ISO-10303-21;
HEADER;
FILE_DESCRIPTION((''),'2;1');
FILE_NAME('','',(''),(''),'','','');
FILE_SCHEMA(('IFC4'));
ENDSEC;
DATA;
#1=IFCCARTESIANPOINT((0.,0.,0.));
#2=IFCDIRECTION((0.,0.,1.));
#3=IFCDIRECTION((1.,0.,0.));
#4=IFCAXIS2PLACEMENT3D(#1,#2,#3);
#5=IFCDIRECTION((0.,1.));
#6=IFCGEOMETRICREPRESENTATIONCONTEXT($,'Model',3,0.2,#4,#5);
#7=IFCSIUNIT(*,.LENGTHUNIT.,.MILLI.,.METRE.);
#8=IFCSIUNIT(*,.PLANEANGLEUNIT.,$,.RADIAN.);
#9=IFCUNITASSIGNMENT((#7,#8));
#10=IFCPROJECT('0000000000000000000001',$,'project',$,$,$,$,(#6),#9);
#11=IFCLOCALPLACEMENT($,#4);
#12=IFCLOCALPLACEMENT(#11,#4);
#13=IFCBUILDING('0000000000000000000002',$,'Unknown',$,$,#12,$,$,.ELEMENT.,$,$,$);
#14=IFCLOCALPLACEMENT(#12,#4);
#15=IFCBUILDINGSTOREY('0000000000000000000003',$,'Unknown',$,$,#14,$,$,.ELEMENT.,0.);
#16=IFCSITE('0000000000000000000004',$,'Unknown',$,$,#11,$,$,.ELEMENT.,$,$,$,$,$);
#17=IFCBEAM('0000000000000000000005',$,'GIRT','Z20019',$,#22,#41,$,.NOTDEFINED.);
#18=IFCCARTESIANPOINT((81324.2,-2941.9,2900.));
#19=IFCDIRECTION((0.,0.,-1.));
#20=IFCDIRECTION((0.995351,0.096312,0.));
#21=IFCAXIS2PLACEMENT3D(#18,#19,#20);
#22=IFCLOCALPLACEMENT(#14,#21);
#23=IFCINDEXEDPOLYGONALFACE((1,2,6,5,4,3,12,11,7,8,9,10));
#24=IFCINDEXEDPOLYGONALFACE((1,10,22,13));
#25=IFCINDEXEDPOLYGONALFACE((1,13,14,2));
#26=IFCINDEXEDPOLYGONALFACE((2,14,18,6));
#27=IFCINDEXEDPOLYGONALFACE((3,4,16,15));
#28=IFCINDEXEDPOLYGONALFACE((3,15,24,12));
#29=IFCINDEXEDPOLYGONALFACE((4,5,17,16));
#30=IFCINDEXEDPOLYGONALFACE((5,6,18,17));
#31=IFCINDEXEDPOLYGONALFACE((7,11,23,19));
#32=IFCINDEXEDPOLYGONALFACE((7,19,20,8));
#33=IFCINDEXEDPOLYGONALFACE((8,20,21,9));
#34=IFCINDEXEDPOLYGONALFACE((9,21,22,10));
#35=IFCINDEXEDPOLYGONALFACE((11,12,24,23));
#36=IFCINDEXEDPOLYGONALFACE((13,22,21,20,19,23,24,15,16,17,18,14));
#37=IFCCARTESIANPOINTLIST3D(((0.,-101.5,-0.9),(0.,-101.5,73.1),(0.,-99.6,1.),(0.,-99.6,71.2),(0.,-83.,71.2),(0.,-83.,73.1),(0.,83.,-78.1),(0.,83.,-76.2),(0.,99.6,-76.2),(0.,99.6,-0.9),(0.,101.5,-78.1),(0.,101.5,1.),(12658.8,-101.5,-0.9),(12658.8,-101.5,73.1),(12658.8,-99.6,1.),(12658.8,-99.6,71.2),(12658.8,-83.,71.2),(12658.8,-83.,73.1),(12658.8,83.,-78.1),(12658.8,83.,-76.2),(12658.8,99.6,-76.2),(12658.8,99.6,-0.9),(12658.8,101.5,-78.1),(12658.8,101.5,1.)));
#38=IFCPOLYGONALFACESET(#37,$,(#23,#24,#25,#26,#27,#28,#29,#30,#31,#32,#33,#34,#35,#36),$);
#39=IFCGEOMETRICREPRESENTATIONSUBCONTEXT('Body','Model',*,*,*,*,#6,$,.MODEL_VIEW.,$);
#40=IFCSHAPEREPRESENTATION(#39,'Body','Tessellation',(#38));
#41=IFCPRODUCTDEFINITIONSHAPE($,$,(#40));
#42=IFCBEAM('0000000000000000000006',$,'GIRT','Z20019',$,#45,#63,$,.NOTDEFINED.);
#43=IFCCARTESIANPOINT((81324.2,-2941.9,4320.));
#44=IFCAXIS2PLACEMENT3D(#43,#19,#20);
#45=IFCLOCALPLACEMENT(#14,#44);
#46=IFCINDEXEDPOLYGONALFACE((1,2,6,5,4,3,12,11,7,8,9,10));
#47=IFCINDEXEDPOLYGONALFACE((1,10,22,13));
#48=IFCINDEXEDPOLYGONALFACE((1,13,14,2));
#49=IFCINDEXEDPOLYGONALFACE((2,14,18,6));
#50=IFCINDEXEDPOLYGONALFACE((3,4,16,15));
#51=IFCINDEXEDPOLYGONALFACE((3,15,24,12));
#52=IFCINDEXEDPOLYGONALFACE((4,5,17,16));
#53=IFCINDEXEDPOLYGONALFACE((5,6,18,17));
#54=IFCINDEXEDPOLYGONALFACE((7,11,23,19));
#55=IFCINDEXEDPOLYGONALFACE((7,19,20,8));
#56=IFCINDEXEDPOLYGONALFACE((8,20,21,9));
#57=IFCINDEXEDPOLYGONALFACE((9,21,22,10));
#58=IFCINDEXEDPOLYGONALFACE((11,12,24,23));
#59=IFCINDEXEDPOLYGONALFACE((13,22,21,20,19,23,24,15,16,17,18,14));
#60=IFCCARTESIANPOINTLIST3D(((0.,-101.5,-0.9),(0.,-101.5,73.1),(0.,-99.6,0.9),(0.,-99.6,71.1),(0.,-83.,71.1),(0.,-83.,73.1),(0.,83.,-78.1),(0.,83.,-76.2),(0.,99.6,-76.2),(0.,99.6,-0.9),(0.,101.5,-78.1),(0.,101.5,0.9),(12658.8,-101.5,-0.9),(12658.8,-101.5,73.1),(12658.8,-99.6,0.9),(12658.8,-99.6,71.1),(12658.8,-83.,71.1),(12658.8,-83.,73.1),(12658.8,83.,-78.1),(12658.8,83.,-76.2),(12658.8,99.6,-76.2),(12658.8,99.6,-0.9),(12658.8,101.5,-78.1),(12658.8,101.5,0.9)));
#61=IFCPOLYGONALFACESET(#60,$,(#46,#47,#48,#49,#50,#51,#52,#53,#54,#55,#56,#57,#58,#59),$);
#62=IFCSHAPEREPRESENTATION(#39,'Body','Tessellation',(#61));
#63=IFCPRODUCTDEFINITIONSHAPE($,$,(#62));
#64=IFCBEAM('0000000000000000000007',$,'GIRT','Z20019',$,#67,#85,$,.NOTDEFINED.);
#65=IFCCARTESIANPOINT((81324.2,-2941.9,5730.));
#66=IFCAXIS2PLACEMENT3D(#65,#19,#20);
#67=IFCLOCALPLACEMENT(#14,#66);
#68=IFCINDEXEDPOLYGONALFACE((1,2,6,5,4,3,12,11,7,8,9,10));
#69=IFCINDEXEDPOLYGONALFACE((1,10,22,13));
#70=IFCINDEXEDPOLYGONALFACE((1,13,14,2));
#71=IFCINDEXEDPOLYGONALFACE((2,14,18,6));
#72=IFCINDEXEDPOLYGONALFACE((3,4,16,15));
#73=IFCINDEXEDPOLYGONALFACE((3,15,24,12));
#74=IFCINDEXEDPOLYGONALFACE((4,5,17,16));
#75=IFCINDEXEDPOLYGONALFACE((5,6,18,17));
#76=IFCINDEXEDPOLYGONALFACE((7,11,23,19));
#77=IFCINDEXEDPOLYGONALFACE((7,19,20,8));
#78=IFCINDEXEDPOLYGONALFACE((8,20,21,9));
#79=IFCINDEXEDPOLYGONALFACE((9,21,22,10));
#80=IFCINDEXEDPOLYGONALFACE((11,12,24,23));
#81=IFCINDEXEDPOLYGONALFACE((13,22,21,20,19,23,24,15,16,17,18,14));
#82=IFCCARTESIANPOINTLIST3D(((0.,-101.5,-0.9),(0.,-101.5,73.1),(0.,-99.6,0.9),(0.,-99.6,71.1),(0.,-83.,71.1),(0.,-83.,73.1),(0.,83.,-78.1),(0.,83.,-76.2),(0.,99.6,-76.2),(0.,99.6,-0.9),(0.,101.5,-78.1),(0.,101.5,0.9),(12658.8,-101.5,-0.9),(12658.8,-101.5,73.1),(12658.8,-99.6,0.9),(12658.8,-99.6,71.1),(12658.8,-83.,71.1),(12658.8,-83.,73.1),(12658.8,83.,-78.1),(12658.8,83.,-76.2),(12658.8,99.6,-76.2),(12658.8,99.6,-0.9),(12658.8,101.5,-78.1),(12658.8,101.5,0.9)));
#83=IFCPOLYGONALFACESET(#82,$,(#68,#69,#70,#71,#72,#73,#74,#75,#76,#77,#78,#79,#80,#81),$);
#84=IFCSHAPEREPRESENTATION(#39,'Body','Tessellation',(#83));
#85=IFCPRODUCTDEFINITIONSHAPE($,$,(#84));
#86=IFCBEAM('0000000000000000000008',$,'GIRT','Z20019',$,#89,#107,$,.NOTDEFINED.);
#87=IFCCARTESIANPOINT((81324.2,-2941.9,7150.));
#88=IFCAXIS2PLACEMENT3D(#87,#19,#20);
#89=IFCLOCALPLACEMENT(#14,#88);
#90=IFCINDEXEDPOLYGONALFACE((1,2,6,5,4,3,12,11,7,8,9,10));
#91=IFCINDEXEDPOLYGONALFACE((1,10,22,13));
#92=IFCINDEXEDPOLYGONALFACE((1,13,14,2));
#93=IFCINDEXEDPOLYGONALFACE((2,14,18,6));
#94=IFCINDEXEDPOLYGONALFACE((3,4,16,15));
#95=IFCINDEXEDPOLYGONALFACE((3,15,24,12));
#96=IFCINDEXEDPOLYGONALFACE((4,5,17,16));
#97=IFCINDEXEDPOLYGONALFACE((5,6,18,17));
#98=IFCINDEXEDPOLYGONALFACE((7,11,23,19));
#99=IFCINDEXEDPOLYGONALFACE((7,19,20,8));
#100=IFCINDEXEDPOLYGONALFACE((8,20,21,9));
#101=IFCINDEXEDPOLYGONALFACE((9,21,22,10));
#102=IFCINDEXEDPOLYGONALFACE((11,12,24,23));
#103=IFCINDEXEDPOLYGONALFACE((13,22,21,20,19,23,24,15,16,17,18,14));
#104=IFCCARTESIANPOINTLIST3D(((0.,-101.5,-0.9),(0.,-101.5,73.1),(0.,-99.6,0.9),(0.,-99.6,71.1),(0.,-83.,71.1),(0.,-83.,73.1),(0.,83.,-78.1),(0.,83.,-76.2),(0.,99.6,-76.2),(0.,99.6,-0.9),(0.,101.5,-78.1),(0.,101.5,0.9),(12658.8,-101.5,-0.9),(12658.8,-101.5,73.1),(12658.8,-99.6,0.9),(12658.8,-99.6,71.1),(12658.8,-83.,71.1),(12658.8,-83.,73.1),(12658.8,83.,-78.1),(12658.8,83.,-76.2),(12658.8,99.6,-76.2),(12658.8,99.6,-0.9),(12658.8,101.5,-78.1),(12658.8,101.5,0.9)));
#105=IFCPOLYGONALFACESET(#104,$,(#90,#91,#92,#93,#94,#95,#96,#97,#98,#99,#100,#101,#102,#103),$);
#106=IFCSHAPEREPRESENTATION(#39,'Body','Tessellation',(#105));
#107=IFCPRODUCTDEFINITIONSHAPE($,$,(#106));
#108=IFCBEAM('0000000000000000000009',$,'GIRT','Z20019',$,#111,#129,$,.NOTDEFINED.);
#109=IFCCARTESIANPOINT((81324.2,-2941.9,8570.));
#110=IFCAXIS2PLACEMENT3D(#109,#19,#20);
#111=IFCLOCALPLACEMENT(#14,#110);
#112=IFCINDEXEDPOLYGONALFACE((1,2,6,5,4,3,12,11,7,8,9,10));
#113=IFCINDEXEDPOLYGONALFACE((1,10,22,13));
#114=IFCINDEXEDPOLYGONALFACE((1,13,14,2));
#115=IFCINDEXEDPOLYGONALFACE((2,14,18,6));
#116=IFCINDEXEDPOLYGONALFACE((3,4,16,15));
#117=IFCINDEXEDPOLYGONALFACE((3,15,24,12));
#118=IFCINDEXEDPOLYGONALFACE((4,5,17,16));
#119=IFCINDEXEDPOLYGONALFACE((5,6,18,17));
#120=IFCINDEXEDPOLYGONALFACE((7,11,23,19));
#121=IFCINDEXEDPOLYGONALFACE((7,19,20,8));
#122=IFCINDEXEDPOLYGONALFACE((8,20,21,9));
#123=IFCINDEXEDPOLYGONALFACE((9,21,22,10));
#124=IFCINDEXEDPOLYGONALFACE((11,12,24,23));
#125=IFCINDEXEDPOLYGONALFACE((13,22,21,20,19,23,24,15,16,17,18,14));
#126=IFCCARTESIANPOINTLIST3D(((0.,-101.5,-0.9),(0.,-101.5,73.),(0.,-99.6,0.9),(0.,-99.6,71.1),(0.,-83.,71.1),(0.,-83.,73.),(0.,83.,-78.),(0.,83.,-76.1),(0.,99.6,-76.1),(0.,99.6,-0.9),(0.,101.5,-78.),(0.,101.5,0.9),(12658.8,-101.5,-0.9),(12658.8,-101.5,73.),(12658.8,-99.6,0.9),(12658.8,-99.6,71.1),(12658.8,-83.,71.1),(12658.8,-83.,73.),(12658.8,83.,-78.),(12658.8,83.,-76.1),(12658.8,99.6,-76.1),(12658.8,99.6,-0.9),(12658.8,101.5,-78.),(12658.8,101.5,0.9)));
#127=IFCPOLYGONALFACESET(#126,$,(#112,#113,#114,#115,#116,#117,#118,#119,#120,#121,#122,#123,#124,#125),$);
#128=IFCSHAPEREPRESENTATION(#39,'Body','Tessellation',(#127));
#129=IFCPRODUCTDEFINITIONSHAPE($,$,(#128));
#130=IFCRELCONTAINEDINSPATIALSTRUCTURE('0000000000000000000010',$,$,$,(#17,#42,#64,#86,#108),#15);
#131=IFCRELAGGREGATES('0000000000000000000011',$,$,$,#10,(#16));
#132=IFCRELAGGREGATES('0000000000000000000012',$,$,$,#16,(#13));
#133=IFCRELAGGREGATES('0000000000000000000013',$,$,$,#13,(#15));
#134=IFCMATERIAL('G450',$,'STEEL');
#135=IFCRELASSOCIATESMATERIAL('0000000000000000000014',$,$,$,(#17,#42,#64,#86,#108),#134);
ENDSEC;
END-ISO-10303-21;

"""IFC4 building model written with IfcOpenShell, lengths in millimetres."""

from ifc_helpers import new_model, si_unit, direction, frame, origin_with_axes, place, context, subcontext, project, spatial, line, indexed_curve, outline, extrude, material, element, save


model = new_model("IFC4")

# Units and contexts
model_context = context("Model", 3, precision=0.2, world=origin_with_axes(), true_north=direction((0.0, 1.0)))
body_context = subcontext(model_context, "Body", "Model", "MODEL_VIEW")
ifc_project = project(units=[si_unit("LENGTHUNIT", "METRE", prefix="MILLI"), si_unit("PLANEANGLEUNIT", "RADIAN")], contexts=[model_context])

# Site, building, storey
site_placement = place(None, origin_with_axes())
site = spatial("IfcSite", under=ifc_project, at=site_placement, Name="Unknown", CompositionType="ELEMENT")
building_placement = place(site_placement, origin_with_axes())
building = spatial("IfcBuilding", under=site, at=building_placement, Name="Unknown", CompositionType="ELEMENT")
storey_placement = place(building_placement, origin_with_axes())
storey = spatial("IfcBuildingStorey", under=building, at=storey_placement, Name="Unknown", CompositionType="ELEMENT", Elevation=0.0)

# Shared definitions
ifc_material_1 = material(Name="G450", Category="STEEL")

# Beams
for number, where, z_axis, x_axis, name in (
    (1, (81324.2, -2941.9, 2900.0), (0.0, 0.0, -1.0), (0.995351, 0.096312, 0.0), "GIRT"),
    (2, (81324.2, -2941.9, 4320.0), (0.0, 0.0, -1.0), (0.995351, 0.096312, 0.0), "GIRT"),
    (3, (81324.2, -2941.9, 5730.0), (0.0, 0.0, -1.0), (0.995351, 0.096312, 0.0), "GIRT"),
    (4, (81324.2, -2941.9, 7150.0), (0.0, 0.0, -1.0), (0.995351, 0.096312, 0.0), "GIRT"),
    (5, (81324.2, -2941.9, 8570.0), (0.0, 0.0, -1.0), (0.995351, 0.096312, 0.0), "GIRT"),
):
    element("IfcBeam", number, at=place(storey_placement, frame(where, z_axis=z_axis, x_axis=x_axis)), inside=storey, material=ifc_material_1, Name=name, Description="Z20019", PredefinedType="NOTDEFINED", context=body_context, shape_type="SolidModel", body=[
        extrude(outline(indexed_curve([(73.0, -101.5), (73.0, -83.0), (71.2, -83.0), (71.2, -99.6), (0.9, -99.6), (0.9, 101.5), (-78.0, 101.5), (-78.0, 83.0), (-76.2, 83.0), (-76.2, 99.6), (-0.9, 99.6), (-0.9, -101.5)], segments=[line(1, 2, 3, 4, 5, 6, 7, 8, 9, 10, 11, 12, 1)])), frame((0.0, 0.0, 0.0), z_axis=(-1.0, 0.0, 0.0), x_axis=(0.0, 0.0, 1.0)), (0.0, 0.0, -1.0), 12658.8),
    ])

save(model, "model.ifc")
